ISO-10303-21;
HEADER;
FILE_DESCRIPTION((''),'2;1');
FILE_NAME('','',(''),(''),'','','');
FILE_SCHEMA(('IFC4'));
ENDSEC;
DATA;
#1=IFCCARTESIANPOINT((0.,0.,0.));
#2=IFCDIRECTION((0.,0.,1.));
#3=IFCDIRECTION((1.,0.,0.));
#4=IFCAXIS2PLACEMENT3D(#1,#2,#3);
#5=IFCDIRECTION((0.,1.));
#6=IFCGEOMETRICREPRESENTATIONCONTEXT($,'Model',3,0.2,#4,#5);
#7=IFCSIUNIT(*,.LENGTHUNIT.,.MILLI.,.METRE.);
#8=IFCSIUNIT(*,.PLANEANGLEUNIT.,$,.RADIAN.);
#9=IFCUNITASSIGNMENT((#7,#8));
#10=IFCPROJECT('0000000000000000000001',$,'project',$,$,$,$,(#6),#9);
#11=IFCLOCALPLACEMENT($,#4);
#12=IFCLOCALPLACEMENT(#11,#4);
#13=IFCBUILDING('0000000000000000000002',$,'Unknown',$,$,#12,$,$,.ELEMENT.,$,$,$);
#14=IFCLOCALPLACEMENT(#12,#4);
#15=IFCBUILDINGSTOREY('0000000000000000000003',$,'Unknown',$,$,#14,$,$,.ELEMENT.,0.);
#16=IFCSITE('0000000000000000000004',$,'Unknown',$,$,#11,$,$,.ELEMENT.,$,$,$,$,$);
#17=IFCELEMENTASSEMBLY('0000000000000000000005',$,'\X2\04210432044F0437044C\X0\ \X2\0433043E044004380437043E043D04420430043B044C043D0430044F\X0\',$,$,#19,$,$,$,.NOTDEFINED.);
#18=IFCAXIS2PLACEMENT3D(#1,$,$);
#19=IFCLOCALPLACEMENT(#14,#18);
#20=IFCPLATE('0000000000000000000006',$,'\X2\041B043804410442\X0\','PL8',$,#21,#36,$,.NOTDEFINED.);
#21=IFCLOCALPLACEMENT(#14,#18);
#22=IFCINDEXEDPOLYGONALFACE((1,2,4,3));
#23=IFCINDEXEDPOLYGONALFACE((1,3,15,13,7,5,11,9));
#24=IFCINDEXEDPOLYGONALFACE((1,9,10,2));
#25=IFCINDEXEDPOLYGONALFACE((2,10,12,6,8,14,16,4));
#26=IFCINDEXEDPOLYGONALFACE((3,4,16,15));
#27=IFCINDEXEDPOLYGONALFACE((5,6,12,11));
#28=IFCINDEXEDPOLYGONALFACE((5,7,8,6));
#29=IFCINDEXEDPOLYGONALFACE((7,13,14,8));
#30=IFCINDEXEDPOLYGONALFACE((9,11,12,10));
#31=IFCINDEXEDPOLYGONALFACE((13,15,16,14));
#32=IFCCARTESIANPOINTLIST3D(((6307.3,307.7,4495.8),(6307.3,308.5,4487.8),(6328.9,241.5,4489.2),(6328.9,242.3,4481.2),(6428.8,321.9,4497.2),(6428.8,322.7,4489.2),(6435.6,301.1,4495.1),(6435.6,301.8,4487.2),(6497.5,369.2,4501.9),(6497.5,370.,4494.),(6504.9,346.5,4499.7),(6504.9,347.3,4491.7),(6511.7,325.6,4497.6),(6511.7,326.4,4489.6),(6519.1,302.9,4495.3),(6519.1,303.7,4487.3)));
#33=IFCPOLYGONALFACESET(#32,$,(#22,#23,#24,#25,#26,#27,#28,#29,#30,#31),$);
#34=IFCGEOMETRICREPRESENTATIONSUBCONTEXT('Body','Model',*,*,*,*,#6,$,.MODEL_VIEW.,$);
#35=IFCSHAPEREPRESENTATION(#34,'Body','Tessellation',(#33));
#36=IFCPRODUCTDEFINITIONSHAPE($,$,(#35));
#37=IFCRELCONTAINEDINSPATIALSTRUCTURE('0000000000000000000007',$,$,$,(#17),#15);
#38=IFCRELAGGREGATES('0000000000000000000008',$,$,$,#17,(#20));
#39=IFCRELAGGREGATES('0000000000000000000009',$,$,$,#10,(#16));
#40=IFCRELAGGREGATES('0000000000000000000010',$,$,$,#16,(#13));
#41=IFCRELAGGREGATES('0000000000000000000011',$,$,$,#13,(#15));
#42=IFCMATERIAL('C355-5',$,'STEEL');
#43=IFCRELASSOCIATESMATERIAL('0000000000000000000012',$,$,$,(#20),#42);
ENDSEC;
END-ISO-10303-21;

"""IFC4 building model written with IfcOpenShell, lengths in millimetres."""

from ifc_helpers import new_model, si_unit, direction, frame, origin_with_axes, place, context, subcontext, project, spatial, line, indexed_curve, outline, extrude, material, element, aggregate, save


model = new_model("IFC4")

# Units and contexts
model_context = context("Model", 3, precision=0.2, world=origin_with_axes(), true_north=direction((0.0, 1.0)))
body_context = subcontext(model_context, "Body", "Model", "MODEL_VIEW")
ifc_project = project(units=[si_unit("LENGTHUNIT", "METRE", prefix="MILLI"), si_unit("PLANEANGLEUNIT", "RADIAN")], contexts=[model_context])

# Site, building, storey
site_placement = place(None, origin_with_axes())
site = spatial("IfcSite", under=ifc_project, at=site_placement, Name="Unknown", CompositionType="ELEMENT")
building_placement = place(site_placement, origin_with_axes())
building = spatial("IfcBuilding", under=site, at=building_placement, Name="Unknown", CompositionType="ELEMENT")
storey_placement = place(building_placement, origin_with_axes())
storey = spatial("IfcBuildingStorey", under=building, at=storey_placement, Name="Unknown", CompositionType="ELEMENT", Elevation=0.0)

# Shared definitions
ifc_material_1 = material(Name="C355-5", Category="STEEL")

# Element assembly, plate
assembly_1_placement = place(storey_placement, frame((6000.0, 172.2, 4478.2), z_axis=(0.308855, -0.946389, -0.094639), x_axis=(0.951109, 0.307322, 0.030732)))
assembly_1 = element("IfcElementAssembly", 1, at=assembly_1_placement, inside=storey, Name="Связь горизонтальная", PredefinedType="NOTDEFINED")
plate_1_placement = place(assembly_1_placement, frame((534.4, 0.0, 35.0), z_axis=(0.0, -1.0, 0.0), x_axis=(-1.0, 0.0, 0.0)))
plate_1 = element("IfcPlate", 2, at=plate_1_placement, material=ifc_material_1, Name="Лист", Description="PL8", PredefinedType="NOTDEFINED", context=body_context, shape_type="SolidModel", body=[
    extrude(outline(indexed_curve([(0.0, 0.0), (200.0, 0.0), (200.0, 70.0), (0.0, 70.0), (0.0, 46.0), (80.0, 46.0), (80.0, 24.0), (0.0, 24.0)], segments=[line(1, 2, 3, 4, 5, 6, 7, 8, 1)])), frame((0.0, 0.0, 4.0), z_axis=(0.0, 0.0, 1.0), x_axis=(1.0, 0.0, 0.0)), (0.0, 0.0, -1.0), 8.0),
])
aggregate(assembly_1, [plate_1])

save(model, "model.ifc")
